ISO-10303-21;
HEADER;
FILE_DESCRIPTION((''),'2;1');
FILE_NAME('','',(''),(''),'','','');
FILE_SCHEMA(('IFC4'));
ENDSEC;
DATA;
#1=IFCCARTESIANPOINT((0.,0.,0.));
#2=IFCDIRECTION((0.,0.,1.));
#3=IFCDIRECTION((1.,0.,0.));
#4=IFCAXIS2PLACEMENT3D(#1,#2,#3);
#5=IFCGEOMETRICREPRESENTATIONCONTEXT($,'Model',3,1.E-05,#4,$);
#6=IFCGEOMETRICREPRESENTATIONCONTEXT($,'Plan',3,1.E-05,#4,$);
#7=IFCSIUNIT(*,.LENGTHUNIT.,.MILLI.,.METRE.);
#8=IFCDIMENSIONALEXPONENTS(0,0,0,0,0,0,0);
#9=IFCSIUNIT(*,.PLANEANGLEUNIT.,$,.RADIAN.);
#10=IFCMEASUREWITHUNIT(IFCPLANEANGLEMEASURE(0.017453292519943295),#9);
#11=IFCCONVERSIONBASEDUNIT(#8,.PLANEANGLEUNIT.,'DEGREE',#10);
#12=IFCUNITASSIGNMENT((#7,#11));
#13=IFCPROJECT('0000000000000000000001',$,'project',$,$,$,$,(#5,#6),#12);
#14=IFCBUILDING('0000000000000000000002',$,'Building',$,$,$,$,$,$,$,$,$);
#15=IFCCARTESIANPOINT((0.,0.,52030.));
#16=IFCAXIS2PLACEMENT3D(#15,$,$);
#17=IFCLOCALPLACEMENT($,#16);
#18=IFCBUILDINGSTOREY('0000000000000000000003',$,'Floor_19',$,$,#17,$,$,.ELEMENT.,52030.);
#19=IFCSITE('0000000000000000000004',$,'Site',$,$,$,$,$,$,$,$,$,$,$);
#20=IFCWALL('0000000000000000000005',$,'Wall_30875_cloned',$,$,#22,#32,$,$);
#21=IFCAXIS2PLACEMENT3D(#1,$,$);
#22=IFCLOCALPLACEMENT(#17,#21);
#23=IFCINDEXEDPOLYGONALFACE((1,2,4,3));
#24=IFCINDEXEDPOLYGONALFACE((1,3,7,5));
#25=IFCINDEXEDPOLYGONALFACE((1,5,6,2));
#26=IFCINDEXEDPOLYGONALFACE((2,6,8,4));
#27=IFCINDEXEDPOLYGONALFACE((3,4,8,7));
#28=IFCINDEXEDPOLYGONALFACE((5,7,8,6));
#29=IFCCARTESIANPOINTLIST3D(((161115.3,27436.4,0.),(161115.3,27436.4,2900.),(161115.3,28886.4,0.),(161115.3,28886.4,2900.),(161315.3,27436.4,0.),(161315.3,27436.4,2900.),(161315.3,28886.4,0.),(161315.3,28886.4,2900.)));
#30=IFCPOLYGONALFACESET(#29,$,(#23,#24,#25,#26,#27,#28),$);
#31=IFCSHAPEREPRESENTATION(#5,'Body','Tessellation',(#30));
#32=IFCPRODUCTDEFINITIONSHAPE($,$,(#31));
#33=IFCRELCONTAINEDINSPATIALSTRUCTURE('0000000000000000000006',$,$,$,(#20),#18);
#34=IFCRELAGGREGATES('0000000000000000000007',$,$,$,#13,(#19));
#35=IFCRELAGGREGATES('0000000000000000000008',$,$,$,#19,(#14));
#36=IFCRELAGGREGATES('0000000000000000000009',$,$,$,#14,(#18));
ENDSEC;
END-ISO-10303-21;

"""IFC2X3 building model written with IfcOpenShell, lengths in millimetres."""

from ifc_helpers import new_model, entity, si_unit, converted_unit, frame, origin_with_axes, origin_2d, place, context, project, spatial, rectangle, extrude, source, transform, mapped, element, save


model = new_model("IFC2X3")

# Units and contexts
model_context = context("Model", 3, precision=1e-05, world=origin_with_axes())
plan_context = context("Plan", 3, precision=1e-05, world=origin_with_axes())
ifc_project = project(units=[si_unit("LENGTHUNIT", "METRE", prefix="MILLI"), converted_unit("PLANEANGLEUNIT", "DEGREE", entity("IfcPlaneAngleMeasure", 0.017453292519943295), si_unit("PLANEANGLEUNIT", "RADIAN"), dimensions=[0, 0, 0, 0, 0, 0, 0])], contexts=[model_context, plan_context])

# Site, building, storey
site = spatial("IfcSite", under=ifc_project, Name="Site")
building = spatial("IfcBuilding", under=site, Name="Building")
storey_placement = place(None, frame((0.0, 0.0, 52030.0)))
storey = spatial("IfcBuildingStorey", under=building, at=storey_placement, Name="Floor_19", CompositionType="ELEMENT", Elevation=52030.0)

# Wall
shared_shape_1 = source(origin_with_axes(), model_context, "Body", "SweptSolid", [
    extrude(rectangle(XDim=1450.0, YDim=200.0, at=origin_2d()), origin_with_axes(), (0.0, 0.0, 1.0), 2900.0),
])
wall_1_placement = place(storey_placement, frame((161215.3, 28161.4, 0.0), z_axis=(0.0, 0.0, 1.0), x_axis=(0.0, 1450.0, 0.0)))
element("IfcWall", 1, at=wall_1_placement, inside=storey, Name="Wall_30875_cloned", context=model_context, shape_type="MappedRepresentation", body=[
    mapped(shared_shape_1, transform((0.0, 0.0, 0.0), x_axis=(1.0, 0.0, 0.0), y_axis=(0.0, 1.0, 0.0), z_axis=(0.0, 0.0, 1.0), scale=1.0)),
])

save(model, "model.ifc")
